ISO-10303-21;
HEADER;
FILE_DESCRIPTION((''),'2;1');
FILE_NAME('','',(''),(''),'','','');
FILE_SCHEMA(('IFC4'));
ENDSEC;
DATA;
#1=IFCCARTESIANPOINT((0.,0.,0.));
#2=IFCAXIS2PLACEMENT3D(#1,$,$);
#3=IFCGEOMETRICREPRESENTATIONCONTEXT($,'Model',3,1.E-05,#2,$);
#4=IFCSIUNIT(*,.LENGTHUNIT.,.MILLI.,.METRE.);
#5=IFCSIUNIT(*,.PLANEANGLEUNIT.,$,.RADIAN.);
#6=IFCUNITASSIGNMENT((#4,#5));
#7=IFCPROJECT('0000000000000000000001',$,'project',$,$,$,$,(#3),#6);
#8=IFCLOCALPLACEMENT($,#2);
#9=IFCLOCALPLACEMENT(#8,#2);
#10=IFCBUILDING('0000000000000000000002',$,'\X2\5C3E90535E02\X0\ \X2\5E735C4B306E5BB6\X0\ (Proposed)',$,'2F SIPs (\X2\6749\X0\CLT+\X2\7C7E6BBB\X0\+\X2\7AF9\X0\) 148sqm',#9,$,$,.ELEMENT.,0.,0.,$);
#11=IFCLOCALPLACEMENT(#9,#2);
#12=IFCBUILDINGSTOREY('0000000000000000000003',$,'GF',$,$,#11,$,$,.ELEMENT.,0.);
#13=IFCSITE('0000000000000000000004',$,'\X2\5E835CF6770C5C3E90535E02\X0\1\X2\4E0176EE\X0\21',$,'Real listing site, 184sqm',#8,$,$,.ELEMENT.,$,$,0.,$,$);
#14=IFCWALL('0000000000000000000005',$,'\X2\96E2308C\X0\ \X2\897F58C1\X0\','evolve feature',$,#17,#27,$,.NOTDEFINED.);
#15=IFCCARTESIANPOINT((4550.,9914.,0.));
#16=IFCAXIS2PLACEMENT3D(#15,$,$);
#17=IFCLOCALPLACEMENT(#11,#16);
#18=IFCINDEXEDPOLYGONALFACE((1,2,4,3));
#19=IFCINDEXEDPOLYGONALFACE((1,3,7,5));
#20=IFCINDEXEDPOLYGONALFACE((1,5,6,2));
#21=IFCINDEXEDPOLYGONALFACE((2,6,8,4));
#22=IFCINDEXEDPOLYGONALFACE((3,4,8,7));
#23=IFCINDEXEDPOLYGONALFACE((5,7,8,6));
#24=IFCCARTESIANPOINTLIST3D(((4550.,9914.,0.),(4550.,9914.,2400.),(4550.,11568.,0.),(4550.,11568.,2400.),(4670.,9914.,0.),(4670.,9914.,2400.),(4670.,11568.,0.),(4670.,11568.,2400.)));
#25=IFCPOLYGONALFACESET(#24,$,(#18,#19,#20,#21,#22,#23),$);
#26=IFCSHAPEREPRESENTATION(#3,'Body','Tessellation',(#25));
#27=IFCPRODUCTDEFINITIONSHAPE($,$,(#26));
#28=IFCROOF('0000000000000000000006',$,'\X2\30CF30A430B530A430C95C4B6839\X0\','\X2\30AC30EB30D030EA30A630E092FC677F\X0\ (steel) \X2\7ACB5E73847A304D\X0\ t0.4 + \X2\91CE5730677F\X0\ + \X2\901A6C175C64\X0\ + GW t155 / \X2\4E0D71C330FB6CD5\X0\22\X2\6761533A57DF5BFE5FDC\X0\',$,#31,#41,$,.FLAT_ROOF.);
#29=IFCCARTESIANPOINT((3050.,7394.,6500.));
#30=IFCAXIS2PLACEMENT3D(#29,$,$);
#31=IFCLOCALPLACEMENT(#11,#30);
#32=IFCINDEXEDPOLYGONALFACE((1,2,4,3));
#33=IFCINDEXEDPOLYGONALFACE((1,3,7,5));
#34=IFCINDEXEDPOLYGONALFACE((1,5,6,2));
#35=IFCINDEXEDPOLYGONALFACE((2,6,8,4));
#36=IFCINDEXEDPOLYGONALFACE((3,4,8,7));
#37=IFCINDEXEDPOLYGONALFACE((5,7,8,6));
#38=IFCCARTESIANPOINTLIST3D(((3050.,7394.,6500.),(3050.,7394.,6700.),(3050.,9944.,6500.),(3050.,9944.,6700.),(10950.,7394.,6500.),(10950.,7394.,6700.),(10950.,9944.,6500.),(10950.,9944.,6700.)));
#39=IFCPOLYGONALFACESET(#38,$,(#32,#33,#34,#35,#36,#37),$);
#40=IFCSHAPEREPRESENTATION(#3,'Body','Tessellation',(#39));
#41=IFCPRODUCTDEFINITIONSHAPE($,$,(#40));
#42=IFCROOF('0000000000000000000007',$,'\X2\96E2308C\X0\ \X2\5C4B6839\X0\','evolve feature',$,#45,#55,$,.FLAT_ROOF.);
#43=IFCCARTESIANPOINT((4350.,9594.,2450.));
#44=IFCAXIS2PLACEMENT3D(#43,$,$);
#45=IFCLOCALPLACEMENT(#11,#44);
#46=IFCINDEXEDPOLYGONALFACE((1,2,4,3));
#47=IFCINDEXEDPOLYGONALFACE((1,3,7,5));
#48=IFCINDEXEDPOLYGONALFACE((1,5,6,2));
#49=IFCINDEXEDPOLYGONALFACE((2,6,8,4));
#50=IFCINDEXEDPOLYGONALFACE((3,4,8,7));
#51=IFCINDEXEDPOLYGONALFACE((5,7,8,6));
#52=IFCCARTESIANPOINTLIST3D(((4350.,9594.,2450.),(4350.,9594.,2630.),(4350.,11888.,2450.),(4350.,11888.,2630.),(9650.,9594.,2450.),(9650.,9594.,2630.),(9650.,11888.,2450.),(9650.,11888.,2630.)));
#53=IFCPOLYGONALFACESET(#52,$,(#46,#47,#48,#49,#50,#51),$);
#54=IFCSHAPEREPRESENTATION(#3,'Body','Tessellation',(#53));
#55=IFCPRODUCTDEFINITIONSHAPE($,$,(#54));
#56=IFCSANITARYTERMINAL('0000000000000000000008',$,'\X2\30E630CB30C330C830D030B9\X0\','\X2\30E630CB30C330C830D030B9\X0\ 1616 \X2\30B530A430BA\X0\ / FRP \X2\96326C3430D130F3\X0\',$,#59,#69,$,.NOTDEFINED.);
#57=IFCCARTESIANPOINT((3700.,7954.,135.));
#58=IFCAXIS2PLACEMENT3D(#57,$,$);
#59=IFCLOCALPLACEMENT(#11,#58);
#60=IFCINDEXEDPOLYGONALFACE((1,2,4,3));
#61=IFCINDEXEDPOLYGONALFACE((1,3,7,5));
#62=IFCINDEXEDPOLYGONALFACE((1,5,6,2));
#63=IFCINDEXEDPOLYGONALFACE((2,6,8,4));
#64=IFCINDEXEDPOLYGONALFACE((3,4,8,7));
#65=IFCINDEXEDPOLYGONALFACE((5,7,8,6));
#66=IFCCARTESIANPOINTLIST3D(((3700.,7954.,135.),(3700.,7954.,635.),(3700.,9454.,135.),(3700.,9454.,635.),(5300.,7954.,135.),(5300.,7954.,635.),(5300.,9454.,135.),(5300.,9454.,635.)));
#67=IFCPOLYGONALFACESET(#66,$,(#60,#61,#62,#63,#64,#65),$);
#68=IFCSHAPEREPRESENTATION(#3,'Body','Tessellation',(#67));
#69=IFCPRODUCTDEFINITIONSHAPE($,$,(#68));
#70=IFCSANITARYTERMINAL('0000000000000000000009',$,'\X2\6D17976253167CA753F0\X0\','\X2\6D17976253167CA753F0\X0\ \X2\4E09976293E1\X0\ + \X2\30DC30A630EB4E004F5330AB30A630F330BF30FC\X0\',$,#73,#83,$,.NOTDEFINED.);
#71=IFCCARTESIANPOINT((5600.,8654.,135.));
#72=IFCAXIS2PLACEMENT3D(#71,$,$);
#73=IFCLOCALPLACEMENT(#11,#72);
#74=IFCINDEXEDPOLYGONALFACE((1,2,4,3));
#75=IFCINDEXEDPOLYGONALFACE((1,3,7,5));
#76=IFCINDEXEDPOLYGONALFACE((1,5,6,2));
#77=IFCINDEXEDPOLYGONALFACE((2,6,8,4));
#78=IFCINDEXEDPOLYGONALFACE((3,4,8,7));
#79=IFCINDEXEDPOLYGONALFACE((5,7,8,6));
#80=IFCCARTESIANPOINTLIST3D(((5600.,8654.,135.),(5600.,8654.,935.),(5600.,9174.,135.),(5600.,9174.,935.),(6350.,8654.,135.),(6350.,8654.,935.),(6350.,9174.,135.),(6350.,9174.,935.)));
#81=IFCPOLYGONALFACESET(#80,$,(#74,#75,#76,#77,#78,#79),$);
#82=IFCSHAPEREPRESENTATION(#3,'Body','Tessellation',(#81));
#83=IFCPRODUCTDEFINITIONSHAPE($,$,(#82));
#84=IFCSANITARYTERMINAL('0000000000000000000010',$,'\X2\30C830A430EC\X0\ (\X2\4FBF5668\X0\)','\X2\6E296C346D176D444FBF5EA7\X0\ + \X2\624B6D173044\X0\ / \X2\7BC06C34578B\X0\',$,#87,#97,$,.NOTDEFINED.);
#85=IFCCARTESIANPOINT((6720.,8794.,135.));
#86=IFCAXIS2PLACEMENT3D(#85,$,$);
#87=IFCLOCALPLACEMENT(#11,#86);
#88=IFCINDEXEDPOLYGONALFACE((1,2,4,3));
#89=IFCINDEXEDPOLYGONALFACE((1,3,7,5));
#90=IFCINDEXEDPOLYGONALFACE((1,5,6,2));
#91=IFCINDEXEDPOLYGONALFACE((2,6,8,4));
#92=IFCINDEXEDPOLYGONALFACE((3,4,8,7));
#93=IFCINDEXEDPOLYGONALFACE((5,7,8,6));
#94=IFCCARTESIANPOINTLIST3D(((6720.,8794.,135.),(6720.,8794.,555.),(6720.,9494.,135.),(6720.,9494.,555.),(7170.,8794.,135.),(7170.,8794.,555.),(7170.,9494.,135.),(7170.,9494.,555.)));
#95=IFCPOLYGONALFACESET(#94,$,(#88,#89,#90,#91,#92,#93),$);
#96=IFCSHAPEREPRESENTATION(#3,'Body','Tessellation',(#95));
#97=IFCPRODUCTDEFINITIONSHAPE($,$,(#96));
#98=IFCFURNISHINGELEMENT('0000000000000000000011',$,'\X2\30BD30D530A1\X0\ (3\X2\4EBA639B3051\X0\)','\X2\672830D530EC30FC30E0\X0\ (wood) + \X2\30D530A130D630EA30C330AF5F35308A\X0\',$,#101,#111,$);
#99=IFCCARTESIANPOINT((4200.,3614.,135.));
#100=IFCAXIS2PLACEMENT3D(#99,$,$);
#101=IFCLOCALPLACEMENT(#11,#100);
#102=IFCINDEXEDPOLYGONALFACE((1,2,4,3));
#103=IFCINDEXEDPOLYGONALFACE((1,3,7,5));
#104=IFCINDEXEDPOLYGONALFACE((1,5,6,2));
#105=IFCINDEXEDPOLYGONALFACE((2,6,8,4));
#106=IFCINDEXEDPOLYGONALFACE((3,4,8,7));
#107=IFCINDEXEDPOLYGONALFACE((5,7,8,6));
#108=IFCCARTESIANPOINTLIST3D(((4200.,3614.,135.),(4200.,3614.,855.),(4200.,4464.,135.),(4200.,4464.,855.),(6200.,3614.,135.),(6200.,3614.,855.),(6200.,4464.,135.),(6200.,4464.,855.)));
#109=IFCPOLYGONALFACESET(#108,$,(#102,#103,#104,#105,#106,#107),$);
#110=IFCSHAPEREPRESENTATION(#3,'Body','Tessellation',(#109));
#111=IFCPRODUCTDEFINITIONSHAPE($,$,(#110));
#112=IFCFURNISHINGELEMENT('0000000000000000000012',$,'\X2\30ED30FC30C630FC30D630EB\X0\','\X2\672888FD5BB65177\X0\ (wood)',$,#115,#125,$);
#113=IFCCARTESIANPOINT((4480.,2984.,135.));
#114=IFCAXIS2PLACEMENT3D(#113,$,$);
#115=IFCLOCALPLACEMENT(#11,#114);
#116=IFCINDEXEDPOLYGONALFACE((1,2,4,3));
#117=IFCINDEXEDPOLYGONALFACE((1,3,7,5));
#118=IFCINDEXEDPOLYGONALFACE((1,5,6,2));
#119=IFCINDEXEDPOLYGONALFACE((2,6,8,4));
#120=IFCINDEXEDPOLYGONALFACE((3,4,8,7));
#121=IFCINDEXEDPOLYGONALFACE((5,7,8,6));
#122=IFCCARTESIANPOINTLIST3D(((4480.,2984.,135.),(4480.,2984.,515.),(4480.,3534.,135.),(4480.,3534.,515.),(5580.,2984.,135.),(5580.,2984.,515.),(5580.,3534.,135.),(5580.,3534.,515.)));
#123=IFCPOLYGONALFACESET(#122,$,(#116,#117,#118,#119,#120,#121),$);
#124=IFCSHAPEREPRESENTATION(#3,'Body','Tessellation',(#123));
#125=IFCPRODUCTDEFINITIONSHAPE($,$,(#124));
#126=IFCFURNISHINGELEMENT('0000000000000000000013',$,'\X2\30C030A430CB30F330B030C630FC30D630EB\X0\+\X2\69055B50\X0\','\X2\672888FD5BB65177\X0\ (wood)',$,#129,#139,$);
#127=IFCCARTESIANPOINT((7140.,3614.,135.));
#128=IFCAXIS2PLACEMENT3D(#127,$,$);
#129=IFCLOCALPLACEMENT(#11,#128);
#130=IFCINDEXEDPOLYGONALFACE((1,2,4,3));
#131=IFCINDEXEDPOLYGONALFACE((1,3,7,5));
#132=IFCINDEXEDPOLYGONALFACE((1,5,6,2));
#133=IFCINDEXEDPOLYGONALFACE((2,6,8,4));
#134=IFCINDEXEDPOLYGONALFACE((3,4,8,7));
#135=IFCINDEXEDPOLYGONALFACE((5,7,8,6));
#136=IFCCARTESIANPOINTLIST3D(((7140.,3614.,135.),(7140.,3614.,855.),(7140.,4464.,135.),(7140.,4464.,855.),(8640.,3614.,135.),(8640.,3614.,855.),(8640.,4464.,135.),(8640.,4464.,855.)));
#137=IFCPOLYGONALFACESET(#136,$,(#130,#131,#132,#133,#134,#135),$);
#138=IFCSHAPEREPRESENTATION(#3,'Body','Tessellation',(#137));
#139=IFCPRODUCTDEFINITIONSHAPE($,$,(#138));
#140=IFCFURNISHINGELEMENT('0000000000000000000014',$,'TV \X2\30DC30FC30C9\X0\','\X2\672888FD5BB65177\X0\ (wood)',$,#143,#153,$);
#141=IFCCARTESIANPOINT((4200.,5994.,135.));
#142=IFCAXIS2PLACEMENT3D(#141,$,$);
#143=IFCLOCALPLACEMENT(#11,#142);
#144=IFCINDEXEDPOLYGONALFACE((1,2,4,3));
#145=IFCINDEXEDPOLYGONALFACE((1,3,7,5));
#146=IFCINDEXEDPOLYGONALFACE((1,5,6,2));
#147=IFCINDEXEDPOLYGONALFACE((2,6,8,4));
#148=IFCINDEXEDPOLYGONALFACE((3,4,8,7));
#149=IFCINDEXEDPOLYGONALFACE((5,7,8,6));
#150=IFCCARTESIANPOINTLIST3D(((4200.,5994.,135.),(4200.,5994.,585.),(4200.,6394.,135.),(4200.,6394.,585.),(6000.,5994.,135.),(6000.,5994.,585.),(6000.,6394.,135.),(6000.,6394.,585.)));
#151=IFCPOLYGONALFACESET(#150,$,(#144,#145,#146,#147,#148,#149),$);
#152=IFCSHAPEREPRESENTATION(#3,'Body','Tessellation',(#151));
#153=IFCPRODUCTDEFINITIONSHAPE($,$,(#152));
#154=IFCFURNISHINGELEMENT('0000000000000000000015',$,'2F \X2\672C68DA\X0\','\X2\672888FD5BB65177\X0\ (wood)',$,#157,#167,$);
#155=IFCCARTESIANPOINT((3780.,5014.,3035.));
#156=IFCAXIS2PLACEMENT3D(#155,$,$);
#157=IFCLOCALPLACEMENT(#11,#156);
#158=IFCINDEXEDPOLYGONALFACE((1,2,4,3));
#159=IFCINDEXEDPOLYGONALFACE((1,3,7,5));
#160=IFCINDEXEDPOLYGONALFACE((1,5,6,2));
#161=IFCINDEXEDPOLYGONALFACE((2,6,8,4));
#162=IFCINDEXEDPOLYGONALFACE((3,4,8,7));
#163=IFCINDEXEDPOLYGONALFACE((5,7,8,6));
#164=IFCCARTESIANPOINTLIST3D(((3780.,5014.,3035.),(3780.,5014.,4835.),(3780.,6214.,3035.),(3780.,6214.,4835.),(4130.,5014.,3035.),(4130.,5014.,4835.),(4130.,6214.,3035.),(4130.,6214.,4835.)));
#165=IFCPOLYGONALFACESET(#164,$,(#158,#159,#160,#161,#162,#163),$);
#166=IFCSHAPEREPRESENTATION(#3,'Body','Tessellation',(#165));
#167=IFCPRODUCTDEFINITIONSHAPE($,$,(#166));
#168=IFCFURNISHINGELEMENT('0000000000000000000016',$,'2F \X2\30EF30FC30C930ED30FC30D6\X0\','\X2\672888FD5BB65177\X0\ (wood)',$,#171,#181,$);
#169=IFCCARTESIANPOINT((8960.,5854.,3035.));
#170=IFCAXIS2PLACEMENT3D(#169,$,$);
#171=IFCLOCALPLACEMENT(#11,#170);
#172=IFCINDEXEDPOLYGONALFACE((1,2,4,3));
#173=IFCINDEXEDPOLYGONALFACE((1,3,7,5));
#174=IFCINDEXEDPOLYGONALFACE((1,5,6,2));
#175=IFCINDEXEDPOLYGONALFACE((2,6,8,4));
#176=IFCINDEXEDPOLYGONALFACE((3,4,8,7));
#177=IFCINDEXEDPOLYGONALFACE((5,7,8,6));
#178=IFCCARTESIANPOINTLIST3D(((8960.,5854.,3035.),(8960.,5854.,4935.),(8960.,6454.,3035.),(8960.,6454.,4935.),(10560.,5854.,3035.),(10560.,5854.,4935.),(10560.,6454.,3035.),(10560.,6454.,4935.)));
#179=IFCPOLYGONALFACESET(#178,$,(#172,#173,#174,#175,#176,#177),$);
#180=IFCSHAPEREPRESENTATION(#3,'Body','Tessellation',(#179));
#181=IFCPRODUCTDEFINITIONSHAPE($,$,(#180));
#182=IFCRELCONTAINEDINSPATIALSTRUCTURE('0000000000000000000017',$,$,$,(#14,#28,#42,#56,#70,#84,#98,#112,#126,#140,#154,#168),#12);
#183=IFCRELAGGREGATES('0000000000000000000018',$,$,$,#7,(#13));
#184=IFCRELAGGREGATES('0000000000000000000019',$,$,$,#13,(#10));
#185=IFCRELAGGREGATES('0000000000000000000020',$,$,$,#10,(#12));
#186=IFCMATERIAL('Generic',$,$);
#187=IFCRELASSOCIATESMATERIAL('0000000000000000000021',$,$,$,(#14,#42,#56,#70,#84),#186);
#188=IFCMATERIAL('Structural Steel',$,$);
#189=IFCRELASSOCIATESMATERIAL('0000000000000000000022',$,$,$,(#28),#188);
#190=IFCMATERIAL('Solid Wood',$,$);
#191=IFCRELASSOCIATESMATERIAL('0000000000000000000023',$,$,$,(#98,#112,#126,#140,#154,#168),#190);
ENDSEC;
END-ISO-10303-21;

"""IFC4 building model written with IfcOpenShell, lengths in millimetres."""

from ifc_helpers import new_model, si_unit, frame, frame_2d, origin, place, context, project, spatial, rectangle, extrude, material, element, save


model = new_model("IFC4")

# Units and contexts
model_context = context("Model", 3, precision=1e-05, world=origin())
ifc_project = project(units=[si_unit("LENGTHUNIT", "METRE", prefix="MILLI"), si_unit("PLANEANGLEUNIT", "RADIAN")], contexts=[model_context])

# Site, building, storey
site_placement = place(None, origin())
site = spatial("IfcSite", under=ifc_project, at=site_placement, Name="広島県尾道市1丁目21", ObjectType="Real listing site, 184sqm", CompositionType="ELEMENT", RefElevation=0.0)
building_placement = place(site_placement, origin())
building = spatial("IfcBuilding", under=site, at=building_placement, Name="尾道市 平屋の家 (Proposed)", ObjectType="2F SIPs (杉CLT+籾殻+竹) 148sqm", CompositionType="ELEMENT", ElevationOfRefHeight=0.0, ElevationOfTerrain=0.0)
storey_placement = place(building_placement, origin())
storey = spatial("IfcBuildingStorey", under=building, at=storey_placement, Name="GF", CompositionType="ELEMENT", Elevation=0.0)

# Shared definitions
ifc_material_1 = material(Name="Generic")

# Shared definitions
ifc_material_2 = material(Name="Solid Wood")

# Wall
wall_1_placement = place(storey_placement, frame((4550.0, 9914.0, 0.0)))
element("IfcWall", 1, at=wall_1_placement, inside=storey, material=ifc_material_1, Name="離れ 西壁", Description="evolve feature", PredefinedType="NOTDEFINED", context=model_context, shape_type="SweptSolid", body=[
    extrude(rectangle(XDim=120.0, YDim=1654.0, at=frame_2d((60.0, 827.0))), frame((4550.0, 9914.0, 0.0)), (0.0, 0.0, 1.0), 2400.0),
])

# Roofs
ifc_material_3 = material(Name="Structural Steel")
roof_1_placement = place(storey_placement, frame((3050.0, 7394.0, 6500.0)))
element("IfcRoof", 2, at=roof_1_placement, inside=storey, material=ifc_material_3, Name="ハイサイド屋根", Description="ガルバリウム鋼板 (steel) 立平葺き t0.4 + 野地板 + 通気層 + GW t155 / 不燃・法22条区域対応", PredefinedType="FLAT_ROOF", context=model_context, shape_type="SweptSolid", body=[
    extrude(rectangle(XDim=7900.0, YDim=2550.0, at=frame_2d((3950.0, 1275.0))), frame((3050.0, 7394.0, 6500.0)), (0.0, 0.0, 1.0), 200.0),
])
roof_2_placement = place(storey_placement, frame((4350.0, 9594.0, 2450.0)))
element("IfcRoof", 3, at=roof_2_placement, inside=storey, material=ifc_material_1, Name="離れ 屋根", Description="evolve feature", PredefinedType="FLAT_ROOF", context=model_context, shape_type="SweptSolid", body=[
    extrude(rectangle(XDim=5300.0, YDim=2294.0, at=frame_2d((2650.0, 1147.0))), frame((4350.0, 9594.0, 2450.0)), (0.0, 0.0, 1.0), 180.0),
])

# Sanitary terminals
sanitary_terminal_1_placement = place(storey_placement, frame((3700.0, 7954.0, 135.0)))
element("IfcSanitaryTerminal", 4, at=sanitary_terminal_1_placement, inside=storey, material=ifc_material_1, Name="ユニットバス", Description="ユニットバス 1616 サイズ / FRP 防水パン", PredefinedType="NOTDEFINED", context=model_context, shape_type="SweptSolid", body=[
    extrude(rectangle(XDim=1600.0, YDim=1500.0, at=frame_2d((800.0, 750.0))), frame((3700.0, 7954.0, 135.0)), (0.0, 0.0, 1.0), 500.0),
])
sanitary_terminal_2_placement = place(storey_placement, frame((5600.0, 8654.0, 135.0)))
element("IfcSanitaryTerminal", 5, at=sanitary_terminal_2_placement, inside=storey, material=ifc_material_1, Name="洗面化粧台", Description="洗面化粧台 三面鏡 + ボウル一体カウンター", PredefinedType="NOTDEFINED", context=model_context, shape_type="SweptSolid", body=[
    extrude(rectangle(XDim=750.0, YDim=520.0, at=frame_2d((375.0, 260.0))), frame((5600.0, 8654.0, 135.0)), (0.0, 0.0, 1.0), 800.0),
])
sanitary_terminal_3_placement = place(storey_placement, frame((6720.0, 8794.0, 135.0)))
element("IfcSanitaryTerminal", 6, at=sanitary_terminal_3_placement, inside=storey, material=ifc_material_1, Name="トイレ (便器)", Description="温水洗浄便座 + 手洗い / 節水型", PredefinedType="NOTDEFINED", context=model_context, shape_type="SweptSolid", body=[
    extrude(rectangle(XDim=450.0, YDim=700.0, at=frame_2d((225.0, 350.0))), frame((6720.0, 8794.0, 135.0)), (0.0, 0.0, 1.0), 420.0),
])

# Furnishing elements
furnishing_1_placement = place(storey_placement, frame((4200.0, 3614.0, 135.0)))
element("IfcFurnishingElement", 7, at=furnishing_1_placement, inside=storey, material=ifc_material_2, Name="ソファ (3人掛け)", Description="木フレーム (wood) + ファブリック張り", context=model_context, shape_type="SweptSolid", body=[
    extrude(rectangle(XDim=2000.0, YDim=850.0, at=frame_2d((1000.0, 425.0))), frame((4200.0, 3614.0, 135.0)), (0.0, 0.0, 1.0), 720.0),
])
furnishing_2_placement = place(storey_placement, frame((4480.0, 2984.0, 135.0)))
element("IfcFurnishingElement", 8, at=furnishing_2_placement, inside=storey, material=ifc_material_2, Name="ローテーブル", Description="木製家具 (wood)", context=model_context, shape_type="SweptSolid", body=[
    extrude(rectangle(XDim=1100.0, YDim=550.0, at=frame_2d((550.0, 275.0))), frame((4480.0, 2984.0, 135.0)), (0.0, 0.0, 1.0), 380.0),
])
furnishing_3_placement = place(storey_placement, frame((7140.0, 3614.0, 135.0)))
element("IfcFurnishingElement", 9, at=furnishing_3_placement, inside=storey, material=ifc_material_2, Name="ダイニングテーブル+椅子", Description="木製家具 (wood)", context=model_context, shape_type="SweptSolid", body=[
    extrude(rectangle(XDim=1500.0, YDim=850.0, at=frame_2d((750.0, 425.0))), frame((7140.0, 3614.0, 135.0)), (0.0, 0.0, 1.0), 720.0),
])
furnishing_4_placement = place(storey_placement, frame((4200.0, 5994.0, 135.0)))
element("IfcFurnishingElement", 10, at=furnishing_4_placement, inside=storey, material=ifc_material_2, Name="TV ボード", Description="木製家具 (wood)", context=model_context, shape_type="SweptSolid", body=[
    extrude(rectangle(XDim=1800.0, YDim=400.0, at=frame_2d((900.0, 200.0))), frame((4200.0, 5994.0, 135.0)), (0.0, 0.0, 1.0), 450.0),
])
furnishing_5_placement = place(storey_placement, frame((3780.0, 5014.0, 3035.0)))
element("IfcFurnishingElement", 11, at=furnishing_5_placement, inside=storey, material=ifc_material_2, Name="2F 本棚", Description="木製家具 (wood)", context=model_context, shape_type="SweptSolid", body=[
    extrude(rectangle(XDim=350.0, YDim=1200.0, at=frame_2d((175.0, 600.0))), frame((3780.0, 5014.0, 3035.0)), (0.0, 0.0, 1.0), 1800.0),
])
furnishing_6_placement = place(storey_placement, frame((8960.0, 5854.0, 3035.0)))
element("IfcFurnishingElement", 12, at=furnishing_6_placement, inside=storey, material=ifc_material_2, Name="2F ワードローブ", Description="木製家具 (wood)", context=model_context, shape_type="SweptSolid", body=[
    extrude(rectangle(XDim=1600.0, YDim=600.0, at=frame_2d((800.0, 300.0))), frame((8960.0, 5854.0, 3035.0)), (0.0, 0.0, 1.0), 1900.0),
])

save(model, "model.ifc")
